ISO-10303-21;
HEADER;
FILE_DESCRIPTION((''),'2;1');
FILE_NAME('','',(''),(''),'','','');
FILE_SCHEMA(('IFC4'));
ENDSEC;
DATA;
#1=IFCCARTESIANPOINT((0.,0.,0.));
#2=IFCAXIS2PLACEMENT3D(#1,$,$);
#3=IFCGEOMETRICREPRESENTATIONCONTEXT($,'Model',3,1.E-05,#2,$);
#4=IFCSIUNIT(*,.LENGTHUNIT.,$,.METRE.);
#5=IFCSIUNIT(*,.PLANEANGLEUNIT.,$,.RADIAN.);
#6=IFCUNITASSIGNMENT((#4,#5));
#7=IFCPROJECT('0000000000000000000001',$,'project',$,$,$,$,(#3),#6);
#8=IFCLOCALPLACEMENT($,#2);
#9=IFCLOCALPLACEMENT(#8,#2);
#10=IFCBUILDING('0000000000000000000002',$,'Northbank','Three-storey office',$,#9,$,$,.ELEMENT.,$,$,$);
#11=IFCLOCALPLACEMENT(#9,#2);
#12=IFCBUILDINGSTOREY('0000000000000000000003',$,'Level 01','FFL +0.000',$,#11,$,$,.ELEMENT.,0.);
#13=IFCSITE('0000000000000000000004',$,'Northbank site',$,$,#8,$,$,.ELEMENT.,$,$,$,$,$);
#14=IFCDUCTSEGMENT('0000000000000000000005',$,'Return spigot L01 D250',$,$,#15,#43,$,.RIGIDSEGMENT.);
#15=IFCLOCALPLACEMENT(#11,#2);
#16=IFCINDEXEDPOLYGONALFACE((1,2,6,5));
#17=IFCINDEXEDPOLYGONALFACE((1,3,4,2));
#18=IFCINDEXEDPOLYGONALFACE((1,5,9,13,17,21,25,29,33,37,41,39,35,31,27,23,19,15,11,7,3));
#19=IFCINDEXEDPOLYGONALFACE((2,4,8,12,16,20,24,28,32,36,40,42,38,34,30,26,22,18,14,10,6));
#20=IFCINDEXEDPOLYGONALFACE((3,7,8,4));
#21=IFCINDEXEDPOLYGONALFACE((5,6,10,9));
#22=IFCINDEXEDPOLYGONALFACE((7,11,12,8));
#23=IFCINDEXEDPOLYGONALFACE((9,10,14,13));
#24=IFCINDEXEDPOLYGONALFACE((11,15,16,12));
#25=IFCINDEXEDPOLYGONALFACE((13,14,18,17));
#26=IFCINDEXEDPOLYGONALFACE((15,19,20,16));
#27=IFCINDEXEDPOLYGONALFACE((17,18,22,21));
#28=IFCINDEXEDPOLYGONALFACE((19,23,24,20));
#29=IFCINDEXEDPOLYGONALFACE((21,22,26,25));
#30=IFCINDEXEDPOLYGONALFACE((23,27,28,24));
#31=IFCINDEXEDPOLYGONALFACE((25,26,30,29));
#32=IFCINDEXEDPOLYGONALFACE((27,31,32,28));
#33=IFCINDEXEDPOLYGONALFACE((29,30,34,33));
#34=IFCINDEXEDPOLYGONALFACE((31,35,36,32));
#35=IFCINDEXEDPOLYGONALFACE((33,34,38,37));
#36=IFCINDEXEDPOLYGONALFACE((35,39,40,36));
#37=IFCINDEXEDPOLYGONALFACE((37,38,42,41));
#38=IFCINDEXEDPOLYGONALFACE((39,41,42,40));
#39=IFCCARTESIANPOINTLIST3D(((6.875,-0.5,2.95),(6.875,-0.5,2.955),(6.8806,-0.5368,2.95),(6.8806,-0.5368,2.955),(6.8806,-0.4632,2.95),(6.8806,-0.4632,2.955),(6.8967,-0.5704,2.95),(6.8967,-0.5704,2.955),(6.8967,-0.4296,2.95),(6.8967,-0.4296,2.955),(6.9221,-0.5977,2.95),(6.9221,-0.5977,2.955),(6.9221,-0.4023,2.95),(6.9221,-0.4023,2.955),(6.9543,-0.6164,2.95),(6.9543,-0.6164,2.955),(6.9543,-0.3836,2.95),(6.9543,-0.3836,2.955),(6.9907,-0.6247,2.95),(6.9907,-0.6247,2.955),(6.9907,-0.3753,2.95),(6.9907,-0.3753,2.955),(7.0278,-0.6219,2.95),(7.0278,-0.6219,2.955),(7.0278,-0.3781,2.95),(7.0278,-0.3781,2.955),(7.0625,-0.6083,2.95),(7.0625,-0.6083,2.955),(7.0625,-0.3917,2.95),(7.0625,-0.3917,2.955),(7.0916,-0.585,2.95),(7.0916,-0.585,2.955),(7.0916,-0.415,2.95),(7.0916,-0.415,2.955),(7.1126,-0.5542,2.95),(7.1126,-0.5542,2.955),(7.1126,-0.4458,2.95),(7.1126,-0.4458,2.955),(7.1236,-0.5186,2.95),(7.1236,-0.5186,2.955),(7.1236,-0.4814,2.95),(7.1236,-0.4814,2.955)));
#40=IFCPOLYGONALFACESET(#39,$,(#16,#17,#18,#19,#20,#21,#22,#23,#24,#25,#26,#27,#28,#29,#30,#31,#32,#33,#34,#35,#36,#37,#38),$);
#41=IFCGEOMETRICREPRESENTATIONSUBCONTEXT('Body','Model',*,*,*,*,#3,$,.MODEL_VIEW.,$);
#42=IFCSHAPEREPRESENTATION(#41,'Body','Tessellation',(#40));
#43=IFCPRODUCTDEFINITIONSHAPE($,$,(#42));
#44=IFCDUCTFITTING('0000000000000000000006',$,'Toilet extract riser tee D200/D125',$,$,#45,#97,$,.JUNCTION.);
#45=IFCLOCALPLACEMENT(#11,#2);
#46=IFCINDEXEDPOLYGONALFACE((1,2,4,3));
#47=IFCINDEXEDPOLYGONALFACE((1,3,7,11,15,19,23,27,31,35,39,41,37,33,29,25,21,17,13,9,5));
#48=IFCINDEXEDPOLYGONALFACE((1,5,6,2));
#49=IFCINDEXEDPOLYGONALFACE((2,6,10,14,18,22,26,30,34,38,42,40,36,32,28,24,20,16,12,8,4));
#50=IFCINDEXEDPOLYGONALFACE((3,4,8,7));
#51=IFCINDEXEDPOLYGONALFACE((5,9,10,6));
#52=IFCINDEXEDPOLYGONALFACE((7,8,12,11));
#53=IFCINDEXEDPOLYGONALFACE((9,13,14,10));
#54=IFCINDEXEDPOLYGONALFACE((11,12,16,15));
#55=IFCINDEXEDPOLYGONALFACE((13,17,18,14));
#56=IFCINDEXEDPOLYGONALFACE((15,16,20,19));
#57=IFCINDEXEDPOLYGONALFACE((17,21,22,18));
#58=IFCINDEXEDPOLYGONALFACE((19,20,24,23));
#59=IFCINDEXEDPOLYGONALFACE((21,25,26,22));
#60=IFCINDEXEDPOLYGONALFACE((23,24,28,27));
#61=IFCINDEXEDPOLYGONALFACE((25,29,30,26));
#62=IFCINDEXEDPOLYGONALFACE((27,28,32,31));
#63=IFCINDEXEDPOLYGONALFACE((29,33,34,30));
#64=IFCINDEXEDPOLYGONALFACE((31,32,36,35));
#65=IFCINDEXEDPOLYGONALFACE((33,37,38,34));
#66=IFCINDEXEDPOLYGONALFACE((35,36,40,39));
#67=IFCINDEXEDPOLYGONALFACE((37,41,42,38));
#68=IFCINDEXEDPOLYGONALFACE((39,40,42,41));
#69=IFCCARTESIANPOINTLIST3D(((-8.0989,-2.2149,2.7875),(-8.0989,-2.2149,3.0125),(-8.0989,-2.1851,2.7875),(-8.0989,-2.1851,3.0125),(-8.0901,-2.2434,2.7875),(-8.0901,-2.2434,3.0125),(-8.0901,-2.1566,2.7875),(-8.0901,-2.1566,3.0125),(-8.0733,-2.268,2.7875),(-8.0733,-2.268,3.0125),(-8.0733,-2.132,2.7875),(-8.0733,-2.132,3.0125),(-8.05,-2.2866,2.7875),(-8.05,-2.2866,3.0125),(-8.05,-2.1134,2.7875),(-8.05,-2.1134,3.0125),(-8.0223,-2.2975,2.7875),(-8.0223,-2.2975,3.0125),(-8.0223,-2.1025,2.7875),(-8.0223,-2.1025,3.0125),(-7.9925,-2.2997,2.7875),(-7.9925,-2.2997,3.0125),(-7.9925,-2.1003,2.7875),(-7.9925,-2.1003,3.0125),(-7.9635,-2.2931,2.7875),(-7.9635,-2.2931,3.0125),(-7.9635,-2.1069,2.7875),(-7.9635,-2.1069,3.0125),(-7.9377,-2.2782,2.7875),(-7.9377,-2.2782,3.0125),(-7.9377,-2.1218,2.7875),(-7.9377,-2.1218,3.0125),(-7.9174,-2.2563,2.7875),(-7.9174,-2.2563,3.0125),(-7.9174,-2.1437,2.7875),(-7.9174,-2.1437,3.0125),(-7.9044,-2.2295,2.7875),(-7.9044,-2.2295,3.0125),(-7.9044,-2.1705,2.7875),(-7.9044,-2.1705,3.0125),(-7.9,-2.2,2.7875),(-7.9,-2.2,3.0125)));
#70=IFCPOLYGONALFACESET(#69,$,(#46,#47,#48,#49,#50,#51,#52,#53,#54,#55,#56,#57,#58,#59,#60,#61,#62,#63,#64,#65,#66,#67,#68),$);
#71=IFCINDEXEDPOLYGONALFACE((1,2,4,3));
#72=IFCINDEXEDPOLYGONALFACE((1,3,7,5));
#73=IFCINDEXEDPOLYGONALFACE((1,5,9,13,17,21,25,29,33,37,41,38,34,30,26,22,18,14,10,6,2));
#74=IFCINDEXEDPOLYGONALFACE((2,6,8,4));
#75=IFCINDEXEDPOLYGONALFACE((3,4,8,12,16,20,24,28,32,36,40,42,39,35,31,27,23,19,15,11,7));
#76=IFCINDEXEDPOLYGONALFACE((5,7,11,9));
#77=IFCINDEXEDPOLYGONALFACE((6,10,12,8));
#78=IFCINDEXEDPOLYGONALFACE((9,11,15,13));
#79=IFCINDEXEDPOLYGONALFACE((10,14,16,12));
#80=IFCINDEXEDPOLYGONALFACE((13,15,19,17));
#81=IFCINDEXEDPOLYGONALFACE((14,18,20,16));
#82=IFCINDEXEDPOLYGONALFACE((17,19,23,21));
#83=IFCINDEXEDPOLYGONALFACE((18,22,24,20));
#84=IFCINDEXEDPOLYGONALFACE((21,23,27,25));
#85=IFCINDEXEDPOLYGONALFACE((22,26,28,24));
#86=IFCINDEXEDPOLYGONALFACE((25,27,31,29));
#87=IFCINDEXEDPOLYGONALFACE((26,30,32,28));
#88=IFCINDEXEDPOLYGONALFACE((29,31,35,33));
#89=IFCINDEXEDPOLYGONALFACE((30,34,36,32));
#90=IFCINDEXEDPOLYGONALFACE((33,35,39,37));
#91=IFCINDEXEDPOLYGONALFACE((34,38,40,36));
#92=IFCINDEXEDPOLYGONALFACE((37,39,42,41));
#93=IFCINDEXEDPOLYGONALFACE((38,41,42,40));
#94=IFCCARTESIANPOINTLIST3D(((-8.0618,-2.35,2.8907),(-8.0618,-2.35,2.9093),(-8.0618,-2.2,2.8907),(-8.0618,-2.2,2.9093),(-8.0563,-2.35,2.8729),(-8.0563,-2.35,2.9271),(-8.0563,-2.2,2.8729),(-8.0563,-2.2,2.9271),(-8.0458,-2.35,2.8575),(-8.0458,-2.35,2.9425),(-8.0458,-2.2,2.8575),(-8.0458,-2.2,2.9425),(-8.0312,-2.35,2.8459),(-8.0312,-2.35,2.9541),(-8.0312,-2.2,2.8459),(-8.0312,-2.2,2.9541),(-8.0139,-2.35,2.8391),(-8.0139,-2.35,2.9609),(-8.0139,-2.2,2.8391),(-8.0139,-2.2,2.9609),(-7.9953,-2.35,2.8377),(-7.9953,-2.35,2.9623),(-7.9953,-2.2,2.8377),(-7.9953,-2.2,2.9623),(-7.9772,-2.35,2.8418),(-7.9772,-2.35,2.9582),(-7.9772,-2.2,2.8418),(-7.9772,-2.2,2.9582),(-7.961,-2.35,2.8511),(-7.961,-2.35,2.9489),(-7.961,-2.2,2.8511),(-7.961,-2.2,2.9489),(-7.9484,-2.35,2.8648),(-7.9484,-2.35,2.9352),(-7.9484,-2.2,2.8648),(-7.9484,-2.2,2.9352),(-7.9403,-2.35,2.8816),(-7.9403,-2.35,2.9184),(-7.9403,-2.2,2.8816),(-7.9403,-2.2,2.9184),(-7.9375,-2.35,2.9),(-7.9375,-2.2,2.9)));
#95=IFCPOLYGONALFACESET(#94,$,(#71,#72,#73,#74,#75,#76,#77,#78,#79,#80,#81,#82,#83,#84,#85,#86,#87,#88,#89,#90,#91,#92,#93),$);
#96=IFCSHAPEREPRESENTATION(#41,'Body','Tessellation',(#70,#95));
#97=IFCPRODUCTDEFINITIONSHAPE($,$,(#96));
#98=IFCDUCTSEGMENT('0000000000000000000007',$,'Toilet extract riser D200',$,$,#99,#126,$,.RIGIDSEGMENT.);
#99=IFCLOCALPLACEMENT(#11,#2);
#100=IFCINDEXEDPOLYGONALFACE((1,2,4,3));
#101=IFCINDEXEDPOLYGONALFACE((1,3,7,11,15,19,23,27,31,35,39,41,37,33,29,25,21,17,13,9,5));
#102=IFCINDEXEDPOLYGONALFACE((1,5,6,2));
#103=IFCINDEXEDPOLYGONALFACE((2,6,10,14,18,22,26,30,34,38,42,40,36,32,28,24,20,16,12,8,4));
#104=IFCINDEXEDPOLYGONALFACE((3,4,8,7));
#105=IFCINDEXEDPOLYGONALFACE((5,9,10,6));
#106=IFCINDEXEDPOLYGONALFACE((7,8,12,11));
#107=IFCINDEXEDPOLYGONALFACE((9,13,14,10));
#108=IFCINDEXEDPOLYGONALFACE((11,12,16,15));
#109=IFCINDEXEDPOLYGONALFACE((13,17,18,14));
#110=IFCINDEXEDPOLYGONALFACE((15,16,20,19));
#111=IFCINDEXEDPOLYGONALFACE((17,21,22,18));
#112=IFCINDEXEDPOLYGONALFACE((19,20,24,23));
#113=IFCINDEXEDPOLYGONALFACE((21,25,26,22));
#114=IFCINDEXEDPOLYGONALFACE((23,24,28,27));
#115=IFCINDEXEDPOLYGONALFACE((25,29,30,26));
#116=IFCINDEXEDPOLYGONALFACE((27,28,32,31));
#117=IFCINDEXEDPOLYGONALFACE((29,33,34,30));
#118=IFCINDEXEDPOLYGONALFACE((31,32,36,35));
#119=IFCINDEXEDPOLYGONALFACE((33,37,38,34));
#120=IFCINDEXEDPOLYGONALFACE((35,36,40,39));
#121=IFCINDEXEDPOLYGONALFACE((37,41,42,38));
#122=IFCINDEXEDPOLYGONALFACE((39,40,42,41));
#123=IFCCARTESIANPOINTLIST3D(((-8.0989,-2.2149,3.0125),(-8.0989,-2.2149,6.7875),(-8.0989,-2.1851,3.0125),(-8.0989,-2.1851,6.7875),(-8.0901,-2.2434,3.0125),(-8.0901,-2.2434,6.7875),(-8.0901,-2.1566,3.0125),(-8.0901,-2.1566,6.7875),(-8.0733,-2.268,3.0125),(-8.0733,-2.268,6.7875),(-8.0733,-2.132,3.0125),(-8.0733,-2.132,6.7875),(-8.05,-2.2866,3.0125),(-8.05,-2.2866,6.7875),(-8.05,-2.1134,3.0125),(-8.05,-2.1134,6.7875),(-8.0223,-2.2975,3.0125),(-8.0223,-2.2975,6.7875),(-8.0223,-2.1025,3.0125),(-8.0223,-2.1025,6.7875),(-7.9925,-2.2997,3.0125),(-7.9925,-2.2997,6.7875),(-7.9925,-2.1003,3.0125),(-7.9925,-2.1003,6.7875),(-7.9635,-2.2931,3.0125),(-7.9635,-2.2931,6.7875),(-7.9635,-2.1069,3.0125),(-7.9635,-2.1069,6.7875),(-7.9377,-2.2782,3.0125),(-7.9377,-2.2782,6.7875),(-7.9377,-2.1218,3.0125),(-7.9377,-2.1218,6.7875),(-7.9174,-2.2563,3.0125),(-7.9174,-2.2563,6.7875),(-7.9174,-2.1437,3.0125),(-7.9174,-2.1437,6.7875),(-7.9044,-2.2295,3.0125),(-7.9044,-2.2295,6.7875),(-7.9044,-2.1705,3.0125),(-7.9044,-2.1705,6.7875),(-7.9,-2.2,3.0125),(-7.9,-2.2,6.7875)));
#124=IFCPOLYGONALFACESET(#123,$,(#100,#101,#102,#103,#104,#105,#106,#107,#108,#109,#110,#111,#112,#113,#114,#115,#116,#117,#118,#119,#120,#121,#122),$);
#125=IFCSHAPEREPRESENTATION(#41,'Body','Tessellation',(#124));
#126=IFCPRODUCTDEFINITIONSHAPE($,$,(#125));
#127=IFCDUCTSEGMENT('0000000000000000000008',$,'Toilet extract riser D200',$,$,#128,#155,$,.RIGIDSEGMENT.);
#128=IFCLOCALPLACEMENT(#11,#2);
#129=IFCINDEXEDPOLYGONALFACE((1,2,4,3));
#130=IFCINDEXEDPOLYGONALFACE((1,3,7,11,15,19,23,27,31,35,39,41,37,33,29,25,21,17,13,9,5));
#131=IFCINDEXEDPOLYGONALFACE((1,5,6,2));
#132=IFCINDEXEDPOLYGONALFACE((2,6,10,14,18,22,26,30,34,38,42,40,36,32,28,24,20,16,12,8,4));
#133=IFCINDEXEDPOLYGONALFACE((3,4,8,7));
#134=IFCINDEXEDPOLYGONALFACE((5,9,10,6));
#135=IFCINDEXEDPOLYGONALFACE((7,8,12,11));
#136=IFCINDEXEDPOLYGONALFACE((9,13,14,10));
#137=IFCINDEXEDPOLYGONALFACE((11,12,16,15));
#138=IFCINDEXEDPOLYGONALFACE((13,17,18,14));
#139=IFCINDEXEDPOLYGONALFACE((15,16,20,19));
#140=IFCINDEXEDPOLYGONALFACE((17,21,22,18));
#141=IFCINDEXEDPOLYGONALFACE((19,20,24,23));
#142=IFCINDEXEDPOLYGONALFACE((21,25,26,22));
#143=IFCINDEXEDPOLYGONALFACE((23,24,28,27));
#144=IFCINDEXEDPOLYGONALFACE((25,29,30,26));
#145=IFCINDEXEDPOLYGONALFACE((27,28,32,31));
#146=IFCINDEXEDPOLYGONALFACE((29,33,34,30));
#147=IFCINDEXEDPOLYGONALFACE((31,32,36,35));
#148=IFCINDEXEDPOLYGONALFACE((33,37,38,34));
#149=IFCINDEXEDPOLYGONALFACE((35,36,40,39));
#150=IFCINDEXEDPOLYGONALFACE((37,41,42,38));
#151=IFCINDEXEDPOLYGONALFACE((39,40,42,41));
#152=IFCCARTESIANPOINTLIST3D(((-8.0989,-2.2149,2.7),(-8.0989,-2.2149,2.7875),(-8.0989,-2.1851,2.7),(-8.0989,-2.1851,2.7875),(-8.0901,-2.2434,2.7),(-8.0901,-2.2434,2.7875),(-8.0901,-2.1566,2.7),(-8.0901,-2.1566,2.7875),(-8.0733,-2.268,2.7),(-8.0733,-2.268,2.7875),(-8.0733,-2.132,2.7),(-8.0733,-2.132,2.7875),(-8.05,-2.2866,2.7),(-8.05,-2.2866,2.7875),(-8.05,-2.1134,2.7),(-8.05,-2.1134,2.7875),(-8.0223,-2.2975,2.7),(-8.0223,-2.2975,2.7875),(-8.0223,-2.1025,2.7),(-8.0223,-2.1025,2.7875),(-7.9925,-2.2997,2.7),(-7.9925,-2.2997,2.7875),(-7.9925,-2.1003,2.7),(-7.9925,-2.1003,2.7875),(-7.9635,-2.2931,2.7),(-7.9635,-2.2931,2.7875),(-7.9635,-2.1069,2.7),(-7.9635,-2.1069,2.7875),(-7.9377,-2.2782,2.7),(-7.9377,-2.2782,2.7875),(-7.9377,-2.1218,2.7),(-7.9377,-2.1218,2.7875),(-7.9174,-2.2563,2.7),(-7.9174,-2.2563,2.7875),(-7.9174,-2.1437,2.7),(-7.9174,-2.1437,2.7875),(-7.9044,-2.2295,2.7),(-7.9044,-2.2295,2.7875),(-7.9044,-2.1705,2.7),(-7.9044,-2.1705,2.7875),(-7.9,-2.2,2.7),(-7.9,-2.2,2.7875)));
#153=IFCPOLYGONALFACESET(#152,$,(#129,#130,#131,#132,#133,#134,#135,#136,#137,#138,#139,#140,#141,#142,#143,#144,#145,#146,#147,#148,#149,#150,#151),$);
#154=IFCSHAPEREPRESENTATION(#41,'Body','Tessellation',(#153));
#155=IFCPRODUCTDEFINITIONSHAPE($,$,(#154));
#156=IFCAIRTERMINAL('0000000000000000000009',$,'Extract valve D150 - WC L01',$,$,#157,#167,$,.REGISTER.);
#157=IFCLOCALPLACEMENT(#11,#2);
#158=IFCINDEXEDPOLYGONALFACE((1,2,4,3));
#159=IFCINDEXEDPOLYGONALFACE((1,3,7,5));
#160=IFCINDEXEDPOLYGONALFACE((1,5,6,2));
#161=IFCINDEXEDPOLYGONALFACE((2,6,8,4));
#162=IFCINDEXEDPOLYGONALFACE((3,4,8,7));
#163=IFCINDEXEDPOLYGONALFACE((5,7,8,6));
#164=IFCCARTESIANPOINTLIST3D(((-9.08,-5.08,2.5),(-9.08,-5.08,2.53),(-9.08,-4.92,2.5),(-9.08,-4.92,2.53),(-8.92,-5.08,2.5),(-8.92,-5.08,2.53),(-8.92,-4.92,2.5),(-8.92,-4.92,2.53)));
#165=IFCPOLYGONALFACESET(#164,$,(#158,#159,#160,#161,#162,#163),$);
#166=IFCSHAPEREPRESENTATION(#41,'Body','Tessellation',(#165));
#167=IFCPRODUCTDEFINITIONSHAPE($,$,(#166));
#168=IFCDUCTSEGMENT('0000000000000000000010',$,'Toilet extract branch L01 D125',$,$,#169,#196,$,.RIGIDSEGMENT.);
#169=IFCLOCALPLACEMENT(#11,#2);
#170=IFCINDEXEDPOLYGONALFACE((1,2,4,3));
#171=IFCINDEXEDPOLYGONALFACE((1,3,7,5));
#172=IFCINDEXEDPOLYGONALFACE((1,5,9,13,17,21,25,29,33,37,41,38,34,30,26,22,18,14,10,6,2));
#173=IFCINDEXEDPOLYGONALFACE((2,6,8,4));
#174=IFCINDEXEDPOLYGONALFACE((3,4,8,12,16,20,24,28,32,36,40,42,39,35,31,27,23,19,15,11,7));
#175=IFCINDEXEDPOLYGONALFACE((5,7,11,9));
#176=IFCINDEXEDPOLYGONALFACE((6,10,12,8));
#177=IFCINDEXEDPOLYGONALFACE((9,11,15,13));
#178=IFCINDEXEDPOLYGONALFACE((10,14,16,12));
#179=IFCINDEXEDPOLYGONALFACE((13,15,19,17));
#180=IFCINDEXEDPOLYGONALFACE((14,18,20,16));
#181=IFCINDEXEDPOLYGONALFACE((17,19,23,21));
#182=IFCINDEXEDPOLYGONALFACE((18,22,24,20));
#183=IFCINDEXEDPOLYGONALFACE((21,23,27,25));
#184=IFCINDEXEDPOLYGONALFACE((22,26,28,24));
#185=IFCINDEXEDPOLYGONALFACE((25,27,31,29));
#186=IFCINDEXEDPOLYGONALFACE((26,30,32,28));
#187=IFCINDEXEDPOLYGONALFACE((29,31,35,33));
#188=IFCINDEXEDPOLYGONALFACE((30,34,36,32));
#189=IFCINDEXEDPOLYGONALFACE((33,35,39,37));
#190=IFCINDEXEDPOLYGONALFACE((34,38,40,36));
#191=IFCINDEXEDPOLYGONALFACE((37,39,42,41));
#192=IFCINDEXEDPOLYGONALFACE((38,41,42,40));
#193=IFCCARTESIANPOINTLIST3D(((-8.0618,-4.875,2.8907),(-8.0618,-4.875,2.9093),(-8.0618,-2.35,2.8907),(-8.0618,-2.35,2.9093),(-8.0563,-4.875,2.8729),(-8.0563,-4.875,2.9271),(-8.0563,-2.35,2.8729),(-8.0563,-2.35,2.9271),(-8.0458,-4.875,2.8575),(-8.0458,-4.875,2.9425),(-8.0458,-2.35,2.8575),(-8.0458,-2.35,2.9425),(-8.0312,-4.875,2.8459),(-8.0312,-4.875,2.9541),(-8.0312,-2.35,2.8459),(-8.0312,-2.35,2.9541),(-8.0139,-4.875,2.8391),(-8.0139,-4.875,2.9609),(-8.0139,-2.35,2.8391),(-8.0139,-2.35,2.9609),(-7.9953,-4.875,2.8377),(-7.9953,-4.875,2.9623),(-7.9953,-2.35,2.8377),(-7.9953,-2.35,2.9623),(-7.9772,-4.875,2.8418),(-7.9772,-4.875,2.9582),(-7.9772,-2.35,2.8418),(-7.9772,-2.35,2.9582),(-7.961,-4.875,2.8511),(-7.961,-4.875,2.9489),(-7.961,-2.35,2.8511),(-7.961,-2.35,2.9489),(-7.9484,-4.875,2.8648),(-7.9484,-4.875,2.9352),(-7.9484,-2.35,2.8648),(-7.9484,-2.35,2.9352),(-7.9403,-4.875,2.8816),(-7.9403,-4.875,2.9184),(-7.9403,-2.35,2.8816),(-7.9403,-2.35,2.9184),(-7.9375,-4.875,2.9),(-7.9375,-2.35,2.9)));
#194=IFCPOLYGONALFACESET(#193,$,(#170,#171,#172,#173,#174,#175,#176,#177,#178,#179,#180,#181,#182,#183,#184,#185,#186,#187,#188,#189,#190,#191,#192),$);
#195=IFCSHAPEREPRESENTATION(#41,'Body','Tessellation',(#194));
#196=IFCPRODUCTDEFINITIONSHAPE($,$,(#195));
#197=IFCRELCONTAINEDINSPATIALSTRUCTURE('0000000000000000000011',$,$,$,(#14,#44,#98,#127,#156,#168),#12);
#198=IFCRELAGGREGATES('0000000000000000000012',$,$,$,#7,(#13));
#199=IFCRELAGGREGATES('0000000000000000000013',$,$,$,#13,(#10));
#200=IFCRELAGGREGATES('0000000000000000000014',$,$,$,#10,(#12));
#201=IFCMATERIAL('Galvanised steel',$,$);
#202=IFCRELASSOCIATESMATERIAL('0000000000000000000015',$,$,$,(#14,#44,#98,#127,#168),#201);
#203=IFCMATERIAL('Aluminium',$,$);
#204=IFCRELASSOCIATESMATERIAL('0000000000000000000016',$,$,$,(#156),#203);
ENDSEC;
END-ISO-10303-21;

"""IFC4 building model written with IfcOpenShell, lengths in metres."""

from ifc_helpers import new_model, si_unit, frame, origin, place, context, subcontext, project, spatial, rectangle, circle, extrude, material, element, save


model = new_model("IFC4")

# Units and contexts
model_context = context("Model", 3, precision=1e-05, world=origin())
body_context = subcontext(model_context, "Body", "Model", "MODEL_VIEW")
ifc_project = project(units=[si_unit("LENGTHUNIT", "METRE"), si_unit("PLANEANGLEUNIT", "RADIAN")], contexts=[model_context])

# Site, building, storey
site_placement = place(None, origin())
site = spatial("IfcSite", under=ifc_project, at=site_placement, Name="Northbank site", CompositionType="ELEMENT")
building_placement = place(site_placement, origin())
building = spatial("IfcBuilding", under=site, at=building_placement, Name="Northbank", Description="Three-storey office", CompositionType="ELEMENT")
storey_placement = place(building_placement, origin())
storey = spatial("IfcBuildingStorey", under=building, at=storey_placement, Name="Level 01", Description="FFL +0.000", CompositionType="ELEMENT", Elevation=0.0)

# Shared definitions
ifc_material_1 = material(Name="Galvanised steel")

# Shared definitions
ifc_material_2 = material(Name="Aluminium")

# Duct segment
duct_segment_1_placement = place(storey_placement, origin())
element("IfcDuctSegment", 1, at=duct_segment_1_placement, inside=storey, material=ifc_material_1, Name="Return spigot L01 D250", PredefinedType="RIGIDSEGMENT", context=body_context, shape_type="SweptSolid", body=[
    extrude(circle(Radius=0.125), frame((7.0, -0.5, 2.955), z_axis=(0.0, 0.0, -1.0), x_axis=(-1.0, 0.0, 0.0)), (0.0, 0.0, 1.0), 0.005),
])

# Duct fitting
duct_fitting_placement = place(storey_placement, origin())
element("IfcDuctFitting", 2, at=duct_fitting_placement, inside=storey, material=ifc_material_1, Name="Toilet extract riser tee D200/D125", PredefinedType="JUNCTION", context=body_context, shape_type="SweptSolid", body=[
    extrude(circle(Radius=0.1), frame((-8.0, -2.2, 3.0125), z_axis=(0.0, 0.0, -1.0), x_axis=(1.0, 0.0, 0.0)), (0.0, 0.0, 1.0), 0.225),
    extrude(circle(Radius=0.0625), frame((-8.0, -2.2, 2.9), z_axis=(0.0, -1.0, 0.0), x_axis=(1.0, 0.0, 0.0)), (0.0, 0.0, 1.0), 0.15),
])

# Duct segments
duct_segment_2_placement = place(storey_placement, origin())
element("IfcDuctSegment", 3, at=duct_segment_2_placement, inside=storey, material=ifc_material_1, Name="Toilet extract riser D200", PredefinedType="RIGIDSEGMENT", context=body_context, shape_type="SweptSolid", body=[
    extrude(circle(Radius=0.1), frame((-8.0, -2.2, 6.7875), z_axis=(0.0, 0.0, -1.0), x_axis=(1.0, 0.0, 0.0)), (0.0, 0.0, 1.0), 3.775),
])
duct_segment_3_placement = place(storey_placement, origin())
element("IfcDuctSegment", 4, at=duct_segment_3_placement, inside=storey, material=ifc_material_1, Name="Toilet extract riser D200", PredefinedType="RIGIDSEGMENT", context=body_context, shape_type="SweptSolid", body=[
    extrude(circle(Radius=0.1), frame((-8.0, -2.2, 2.7875), z_axis=(0.0, 0.0, -1.0), x_axis=(1.0, 0.0, 0.0)), (0.0, 0.0, 1.0), 0.0875),
])

# Air terminal
air_terminal_1_placement = place(storey_placement, origin())
element("IfcAirTerminal", 5, at=air_terminal_1_placement, inside=storey, material=ifc_material_2, Name="Extract valve D150 - WC L01", PredefinedType="REGISTER", context=body_context, shape_type="SweptSolid", body=[
    extrude(rectangle(XDim=0.16, YDim=0.16), frame((-9.0, -5.0, 2.5)), (0.0, 0.0, 1.0), 0.03),
])

# Duct segment
duct_segment_4_placement = place(storey_placement, origin())
element("IfcDuctSegment", 6, at=duct_segment_4_placement, inside=storey, material=ifc_material_1, Name="Toilet extract branch L01 D125", PredefinedType="RIGIDSEGMENT", context=body_context, shape_type="SweptSolid", body=[
    extrude(circle(Radius=0.0625), frame((-8.0, -2.35, 2.9), z_axis=(0.0, -1.0, 0.0), x_axis=(1.0, 0.0, 0.0)), (0.0, 0.0, 1.0), 2.525),
])

save(model, "model.ifc")
